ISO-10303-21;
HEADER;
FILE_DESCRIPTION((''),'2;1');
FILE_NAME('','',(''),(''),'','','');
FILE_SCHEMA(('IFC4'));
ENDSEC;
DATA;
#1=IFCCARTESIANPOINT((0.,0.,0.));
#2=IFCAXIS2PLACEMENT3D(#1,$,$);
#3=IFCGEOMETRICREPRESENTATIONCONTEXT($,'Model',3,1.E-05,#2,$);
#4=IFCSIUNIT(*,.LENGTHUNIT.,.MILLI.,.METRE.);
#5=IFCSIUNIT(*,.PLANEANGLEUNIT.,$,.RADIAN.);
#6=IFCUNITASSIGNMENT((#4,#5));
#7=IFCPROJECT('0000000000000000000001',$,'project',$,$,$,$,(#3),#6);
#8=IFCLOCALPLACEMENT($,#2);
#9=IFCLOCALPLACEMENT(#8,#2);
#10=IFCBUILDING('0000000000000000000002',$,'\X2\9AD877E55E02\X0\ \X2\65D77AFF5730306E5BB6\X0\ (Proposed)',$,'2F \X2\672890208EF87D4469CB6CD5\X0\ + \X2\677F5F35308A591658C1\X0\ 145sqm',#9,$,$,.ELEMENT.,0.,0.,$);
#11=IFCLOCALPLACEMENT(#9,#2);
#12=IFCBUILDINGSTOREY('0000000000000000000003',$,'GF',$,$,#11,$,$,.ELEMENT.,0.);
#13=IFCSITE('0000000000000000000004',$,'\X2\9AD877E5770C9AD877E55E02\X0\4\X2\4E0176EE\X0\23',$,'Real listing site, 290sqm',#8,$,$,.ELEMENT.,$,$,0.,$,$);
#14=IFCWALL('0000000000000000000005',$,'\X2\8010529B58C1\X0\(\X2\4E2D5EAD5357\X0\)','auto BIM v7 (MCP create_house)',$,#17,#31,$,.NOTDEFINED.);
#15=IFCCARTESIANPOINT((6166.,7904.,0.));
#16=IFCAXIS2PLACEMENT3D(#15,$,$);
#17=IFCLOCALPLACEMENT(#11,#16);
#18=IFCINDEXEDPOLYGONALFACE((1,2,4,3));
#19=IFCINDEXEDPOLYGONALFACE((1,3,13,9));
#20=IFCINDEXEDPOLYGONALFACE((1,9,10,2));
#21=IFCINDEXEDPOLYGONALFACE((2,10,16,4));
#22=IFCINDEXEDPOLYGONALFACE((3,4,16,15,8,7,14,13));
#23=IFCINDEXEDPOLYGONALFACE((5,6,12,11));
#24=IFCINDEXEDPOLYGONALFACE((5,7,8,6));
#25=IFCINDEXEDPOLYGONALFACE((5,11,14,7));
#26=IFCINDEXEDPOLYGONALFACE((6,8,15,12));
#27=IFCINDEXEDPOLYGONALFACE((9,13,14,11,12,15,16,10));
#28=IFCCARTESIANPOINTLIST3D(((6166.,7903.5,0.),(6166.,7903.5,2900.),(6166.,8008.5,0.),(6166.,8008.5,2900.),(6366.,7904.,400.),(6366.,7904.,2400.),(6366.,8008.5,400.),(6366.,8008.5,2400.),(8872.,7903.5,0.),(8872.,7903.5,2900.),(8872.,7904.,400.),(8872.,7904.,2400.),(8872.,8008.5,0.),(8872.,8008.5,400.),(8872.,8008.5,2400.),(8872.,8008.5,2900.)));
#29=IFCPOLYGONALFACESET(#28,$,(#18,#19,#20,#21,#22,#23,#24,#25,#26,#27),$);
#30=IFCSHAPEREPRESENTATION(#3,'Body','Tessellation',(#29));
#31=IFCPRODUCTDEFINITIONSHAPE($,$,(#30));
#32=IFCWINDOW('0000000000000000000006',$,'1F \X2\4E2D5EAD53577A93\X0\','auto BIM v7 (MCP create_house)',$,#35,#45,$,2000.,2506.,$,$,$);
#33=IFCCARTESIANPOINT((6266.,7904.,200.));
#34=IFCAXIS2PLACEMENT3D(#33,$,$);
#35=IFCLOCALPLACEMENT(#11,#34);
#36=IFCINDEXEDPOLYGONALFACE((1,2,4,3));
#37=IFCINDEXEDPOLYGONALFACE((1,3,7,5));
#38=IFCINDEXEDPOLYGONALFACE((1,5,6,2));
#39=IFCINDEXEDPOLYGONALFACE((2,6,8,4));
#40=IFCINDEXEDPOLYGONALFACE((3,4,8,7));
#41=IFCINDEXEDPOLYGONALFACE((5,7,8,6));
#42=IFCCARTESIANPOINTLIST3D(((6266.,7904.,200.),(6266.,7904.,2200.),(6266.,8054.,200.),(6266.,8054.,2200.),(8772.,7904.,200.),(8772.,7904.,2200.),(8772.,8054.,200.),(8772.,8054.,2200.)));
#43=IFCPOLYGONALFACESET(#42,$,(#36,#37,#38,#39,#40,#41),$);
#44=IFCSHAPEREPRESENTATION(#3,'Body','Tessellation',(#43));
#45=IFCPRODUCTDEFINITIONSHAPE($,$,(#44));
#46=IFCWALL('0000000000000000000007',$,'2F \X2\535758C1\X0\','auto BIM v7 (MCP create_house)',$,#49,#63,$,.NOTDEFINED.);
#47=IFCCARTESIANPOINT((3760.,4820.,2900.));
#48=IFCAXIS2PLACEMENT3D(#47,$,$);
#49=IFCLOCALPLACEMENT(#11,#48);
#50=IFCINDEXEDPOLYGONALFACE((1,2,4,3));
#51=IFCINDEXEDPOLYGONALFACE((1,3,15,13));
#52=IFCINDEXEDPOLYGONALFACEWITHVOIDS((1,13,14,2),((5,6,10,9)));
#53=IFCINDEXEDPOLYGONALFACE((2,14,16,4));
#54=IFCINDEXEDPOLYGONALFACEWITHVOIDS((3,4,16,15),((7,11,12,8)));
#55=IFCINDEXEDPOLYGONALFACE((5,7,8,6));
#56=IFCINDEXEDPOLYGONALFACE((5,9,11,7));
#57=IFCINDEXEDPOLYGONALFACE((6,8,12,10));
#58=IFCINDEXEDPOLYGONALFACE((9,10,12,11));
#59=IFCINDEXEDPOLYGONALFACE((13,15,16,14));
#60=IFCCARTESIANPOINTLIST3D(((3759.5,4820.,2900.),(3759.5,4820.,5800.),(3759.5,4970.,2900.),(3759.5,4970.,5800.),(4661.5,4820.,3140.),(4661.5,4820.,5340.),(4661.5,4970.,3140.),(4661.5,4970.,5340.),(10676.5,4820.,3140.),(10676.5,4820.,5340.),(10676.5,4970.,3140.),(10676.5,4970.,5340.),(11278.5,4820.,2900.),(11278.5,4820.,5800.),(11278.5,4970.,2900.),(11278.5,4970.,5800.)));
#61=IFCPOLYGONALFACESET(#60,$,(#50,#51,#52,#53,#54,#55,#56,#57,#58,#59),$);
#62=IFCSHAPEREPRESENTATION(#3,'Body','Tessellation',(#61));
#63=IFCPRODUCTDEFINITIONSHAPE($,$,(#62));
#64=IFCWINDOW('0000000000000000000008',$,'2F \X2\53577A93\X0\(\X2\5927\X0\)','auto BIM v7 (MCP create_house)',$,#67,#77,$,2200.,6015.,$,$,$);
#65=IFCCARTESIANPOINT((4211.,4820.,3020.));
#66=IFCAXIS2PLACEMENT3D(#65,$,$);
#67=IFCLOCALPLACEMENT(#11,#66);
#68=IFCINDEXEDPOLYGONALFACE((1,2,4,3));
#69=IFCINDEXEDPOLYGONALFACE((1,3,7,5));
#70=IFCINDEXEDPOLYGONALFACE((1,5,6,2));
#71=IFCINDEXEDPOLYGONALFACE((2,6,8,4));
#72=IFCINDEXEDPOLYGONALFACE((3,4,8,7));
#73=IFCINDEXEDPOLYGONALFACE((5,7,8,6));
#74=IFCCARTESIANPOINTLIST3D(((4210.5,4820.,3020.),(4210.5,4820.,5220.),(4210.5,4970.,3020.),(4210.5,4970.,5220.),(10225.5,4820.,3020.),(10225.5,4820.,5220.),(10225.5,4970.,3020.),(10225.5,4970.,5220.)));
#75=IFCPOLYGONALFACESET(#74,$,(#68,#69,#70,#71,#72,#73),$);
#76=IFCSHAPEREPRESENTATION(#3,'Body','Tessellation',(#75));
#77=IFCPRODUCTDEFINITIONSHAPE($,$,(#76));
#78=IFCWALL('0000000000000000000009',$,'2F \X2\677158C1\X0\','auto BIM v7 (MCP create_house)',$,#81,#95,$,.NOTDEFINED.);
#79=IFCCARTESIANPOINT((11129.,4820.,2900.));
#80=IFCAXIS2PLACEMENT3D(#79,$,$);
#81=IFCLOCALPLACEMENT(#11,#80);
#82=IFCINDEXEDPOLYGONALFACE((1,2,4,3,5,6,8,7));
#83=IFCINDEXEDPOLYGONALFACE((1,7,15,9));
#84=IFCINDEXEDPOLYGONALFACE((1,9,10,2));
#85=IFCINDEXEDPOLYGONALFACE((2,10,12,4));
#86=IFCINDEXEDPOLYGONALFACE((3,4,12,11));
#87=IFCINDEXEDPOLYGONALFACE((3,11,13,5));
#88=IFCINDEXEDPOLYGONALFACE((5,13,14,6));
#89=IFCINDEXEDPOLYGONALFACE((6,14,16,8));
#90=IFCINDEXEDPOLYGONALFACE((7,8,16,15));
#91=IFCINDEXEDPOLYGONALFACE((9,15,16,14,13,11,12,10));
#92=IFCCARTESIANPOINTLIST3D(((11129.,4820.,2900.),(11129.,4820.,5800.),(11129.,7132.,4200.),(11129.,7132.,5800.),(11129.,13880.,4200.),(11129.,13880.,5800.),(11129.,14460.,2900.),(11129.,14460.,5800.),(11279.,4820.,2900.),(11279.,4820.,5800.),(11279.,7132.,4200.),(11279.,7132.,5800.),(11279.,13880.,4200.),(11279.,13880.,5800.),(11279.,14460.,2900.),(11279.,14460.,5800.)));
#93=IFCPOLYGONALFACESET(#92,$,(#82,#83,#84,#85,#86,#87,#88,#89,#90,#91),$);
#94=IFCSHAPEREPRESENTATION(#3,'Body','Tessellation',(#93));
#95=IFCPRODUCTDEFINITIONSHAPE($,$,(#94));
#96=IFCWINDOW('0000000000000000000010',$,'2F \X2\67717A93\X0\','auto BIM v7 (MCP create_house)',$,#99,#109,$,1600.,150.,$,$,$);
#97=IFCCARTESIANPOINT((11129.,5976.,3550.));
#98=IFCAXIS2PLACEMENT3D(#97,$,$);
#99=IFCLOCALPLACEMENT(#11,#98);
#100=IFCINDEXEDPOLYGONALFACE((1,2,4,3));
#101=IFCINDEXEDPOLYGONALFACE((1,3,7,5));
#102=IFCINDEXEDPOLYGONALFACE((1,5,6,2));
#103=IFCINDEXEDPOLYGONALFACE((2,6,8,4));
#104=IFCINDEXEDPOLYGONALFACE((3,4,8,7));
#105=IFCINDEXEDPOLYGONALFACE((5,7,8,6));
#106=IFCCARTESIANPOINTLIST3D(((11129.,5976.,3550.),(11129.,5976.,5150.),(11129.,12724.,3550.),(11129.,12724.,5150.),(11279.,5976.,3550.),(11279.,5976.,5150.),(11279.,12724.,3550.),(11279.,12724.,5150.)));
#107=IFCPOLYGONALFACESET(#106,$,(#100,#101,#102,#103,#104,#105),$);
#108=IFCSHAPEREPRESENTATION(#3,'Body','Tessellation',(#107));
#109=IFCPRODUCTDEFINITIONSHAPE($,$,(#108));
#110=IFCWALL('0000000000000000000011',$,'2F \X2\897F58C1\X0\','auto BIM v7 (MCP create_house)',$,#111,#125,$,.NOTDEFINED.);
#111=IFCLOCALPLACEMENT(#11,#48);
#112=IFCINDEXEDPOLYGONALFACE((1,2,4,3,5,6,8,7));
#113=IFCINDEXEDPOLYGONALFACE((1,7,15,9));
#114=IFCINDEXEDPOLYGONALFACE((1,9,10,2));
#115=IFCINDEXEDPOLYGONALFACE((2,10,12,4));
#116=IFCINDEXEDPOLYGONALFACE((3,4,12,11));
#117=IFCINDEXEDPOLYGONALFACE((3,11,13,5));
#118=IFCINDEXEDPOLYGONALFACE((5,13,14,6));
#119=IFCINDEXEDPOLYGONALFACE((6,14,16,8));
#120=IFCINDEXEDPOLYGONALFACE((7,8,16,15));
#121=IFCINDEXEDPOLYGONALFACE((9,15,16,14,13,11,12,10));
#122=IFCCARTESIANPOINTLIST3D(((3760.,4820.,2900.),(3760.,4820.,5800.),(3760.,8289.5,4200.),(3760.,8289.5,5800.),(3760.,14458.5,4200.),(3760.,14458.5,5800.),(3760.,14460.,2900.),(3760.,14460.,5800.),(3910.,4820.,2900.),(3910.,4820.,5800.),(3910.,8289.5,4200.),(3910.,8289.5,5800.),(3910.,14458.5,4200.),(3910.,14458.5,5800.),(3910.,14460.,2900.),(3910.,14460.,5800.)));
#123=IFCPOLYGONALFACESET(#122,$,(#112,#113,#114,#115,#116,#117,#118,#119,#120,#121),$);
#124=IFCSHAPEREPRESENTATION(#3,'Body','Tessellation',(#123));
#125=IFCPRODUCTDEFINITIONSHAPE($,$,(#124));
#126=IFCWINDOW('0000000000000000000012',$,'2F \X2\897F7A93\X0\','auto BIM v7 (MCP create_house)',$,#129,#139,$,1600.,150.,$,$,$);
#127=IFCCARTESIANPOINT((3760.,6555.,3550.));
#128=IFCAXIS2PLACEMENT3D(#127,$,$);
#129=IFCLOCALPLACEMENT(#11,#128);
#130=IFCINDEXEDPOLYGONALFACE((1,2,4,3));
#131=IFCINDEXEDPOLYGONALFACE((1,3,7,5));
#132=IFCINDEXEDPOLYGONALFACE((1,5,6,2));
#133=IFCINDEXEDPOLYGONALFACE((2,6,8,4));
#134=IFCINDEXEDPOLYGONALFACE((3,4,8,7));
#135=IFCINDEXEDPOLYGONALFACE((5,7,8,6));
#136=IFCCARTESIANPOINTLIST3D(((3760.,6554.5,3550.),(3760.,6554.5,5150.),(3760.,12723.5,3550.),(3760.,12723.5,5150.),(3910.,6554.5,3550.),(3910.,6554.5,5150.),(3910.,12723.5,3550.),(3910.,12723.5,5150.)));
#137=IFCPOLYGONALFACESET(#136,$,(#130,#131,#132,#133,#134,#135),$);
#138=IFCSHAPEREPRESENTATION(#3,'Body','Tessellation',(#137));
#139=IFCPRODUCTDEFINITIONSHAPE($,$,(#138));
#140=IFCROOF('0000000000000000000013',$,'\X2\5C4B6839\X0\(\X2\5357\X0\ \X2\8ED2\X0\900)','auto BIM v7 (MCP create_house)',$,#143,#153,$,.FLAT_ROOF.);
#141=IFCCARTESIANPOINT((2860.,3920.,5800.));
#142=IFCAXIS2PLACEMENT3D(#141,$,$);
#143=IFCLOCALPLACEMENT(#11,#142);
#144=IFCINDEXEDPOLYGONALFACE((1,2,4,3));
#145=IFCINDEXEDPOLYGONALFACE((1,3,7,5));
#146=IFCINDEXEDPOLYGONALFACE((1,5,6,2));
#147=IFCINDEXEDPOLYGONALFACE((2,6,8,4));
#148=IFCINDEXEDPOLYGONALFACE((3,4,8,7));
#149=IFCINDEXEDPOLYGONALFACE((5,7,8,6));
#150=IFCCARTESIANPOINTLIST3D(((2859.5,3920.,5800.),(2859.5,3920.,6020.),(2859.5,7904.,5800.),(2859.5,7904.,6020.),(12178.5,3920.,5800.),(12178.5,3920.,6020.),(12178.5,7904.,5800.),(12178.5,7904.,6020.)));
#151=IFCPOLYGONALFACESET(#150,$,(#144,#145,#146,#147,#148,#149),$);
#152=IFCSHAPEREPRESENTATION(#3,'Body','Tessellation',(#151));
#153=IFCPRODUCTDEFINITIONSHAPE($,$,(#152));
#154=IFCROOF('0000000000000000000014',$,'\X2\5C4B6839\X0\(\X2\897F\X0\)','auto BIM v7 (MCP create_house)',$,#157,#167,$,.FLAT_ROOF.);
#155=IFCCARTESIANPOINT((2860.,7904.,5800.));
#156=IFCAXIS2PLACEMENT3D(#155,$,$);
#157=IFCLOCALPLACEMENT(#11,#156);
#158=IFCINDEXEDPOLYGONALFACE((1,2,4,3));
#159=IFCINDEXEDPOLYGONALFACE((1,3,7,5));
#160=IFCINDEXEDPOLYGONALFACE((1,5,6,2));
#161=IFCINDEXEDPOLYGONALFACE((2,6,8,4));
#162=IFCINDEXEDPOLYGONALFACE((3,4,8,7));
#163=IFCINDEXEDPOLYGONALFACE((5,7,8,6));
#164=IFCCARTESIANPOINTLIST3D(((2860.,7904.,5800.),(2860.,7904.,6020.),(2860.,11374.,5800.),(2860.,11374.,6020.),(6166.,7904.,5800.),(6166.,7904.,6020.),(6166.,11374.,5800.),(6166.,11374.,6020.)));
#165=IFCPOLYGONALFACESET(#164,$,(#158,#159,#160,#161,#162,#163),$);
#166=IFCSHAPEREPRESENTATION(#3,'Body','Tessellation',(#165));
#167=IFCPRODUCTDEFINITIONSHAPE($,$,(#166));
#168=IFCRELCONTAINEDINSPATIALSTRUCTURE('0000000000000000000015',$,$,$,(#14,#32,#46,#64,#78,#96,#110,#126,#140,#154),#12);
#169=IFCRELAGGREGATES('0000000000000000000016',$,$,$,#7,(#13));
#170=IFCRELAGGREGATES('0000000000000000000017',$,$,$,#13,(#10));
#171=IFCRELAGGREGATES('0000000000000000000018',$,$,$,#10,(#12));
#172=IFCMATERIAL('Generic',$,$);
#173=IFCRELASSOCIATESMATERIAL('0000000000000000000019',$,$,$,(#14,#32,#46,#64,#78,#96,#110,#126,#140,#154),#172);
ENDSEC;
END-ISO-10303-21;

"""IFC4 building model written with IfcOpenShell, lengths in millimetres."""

from ifc_helpers import new_model, si_unit, frame, frame_2d, origin, place, context, project, spatial, rectangle, extrude, material, element, fill, save


model = new_model("IFC4")

# Units and contexts
model_context = context("Model", 3, precision=1e-05, world=origin())
ifc_project = project(units=[si_unit("LENGTHUNIT", "METRE", prefix="MILLI"), si_unit("PLANEANGLEUNIT", "RADIAN")], contexts=[model_context])

# Site, building, storey
site_placement = place(None, origin())
site = spatial("IfcSite", under=ifc_project, at=site_placement, Name="高知県高知市4丁目23", ObjectType="Real listing site, 290sqm", CompositionType="ELEMENT", RefElevation=0.0)
building_placement = place(site_placement, origin())
building = spatial("IfcBuilding", under=site, at=building_placement, Name="高知市 旗竿地の家 (Proposed)", ObjectType="2F 木造軸組構法 + 板張り外壁 145sqm", CompositionType="ELEMENT", ElevationOfRefHeight=0.0, ElevationOfTerrain=0.0)
storey_placement = place(building_placement, origin())
storey = spatial("IfcBuildingStorey", under=building, at=storey_placement, Name="GF", CompositionType="ELEMENT", Elevation=0.0)

# Shared definitions
ifc_material = material(Name="Generic")

# Wall, opening, window
wall_1_placement = place(storey_placement, frame((6166.0, 7904.0, 0.0)))
wall_1 = element("IfcWall", 1, at=wall_1_placement, inside=storey, material=ifc_material, Name="耐力壁(中庭南)", Description="auto BIM v7 (MCP create_house)", PredefinedType="NOTDEFINED", context=model_context, shape_type="SweptSolid", body=[
    extrude(rectangle(XDim=2706.0, YDim=105.0, at=frame_2d((1353.0, 52.0))), frame((6166.0, 7904.0, 0.0)), (0.0, 0.0, 1.0), 2900.0),
])
opening_1_placement = place(storey_placement, frame((6266.0, 7904.0, 200.0)))
opening_1 = element("IfcOpeningElement", 2, at=opening_1_placement, cuts=wall_1, PredefinedType="NOTDEFINED", context=model_context, shape_type="SweptSolid", body=[
    extrude(rectangle(XDim=2506.0, YDim=150.0, at=frame_2d((1253.0, 75.0))), frame((6266.0, 7904.0, 200.0)), (0.0, 0.0, 1.0), 2000.0),
])
window_1_placement = place(storey_placement, frame((6266.0, 7904.0, 200.0)))
window_1 = element("IfcWindow", 3, at=window_1_placement, inside=storey, material=ifc_material, Name="1F 中庭南窓", Description="auto BIM v7 (MCP create_house)", OverallHeight=2000.0, OverallWidth=2506.0, context=model_context, shape_type="SweptSolid", body=[
    extrude(rectangle(XDim=2506.0, YDim=150.0, at=frame_2d((1253.0, 75.0))), frame((6266.0, 7904.0, 200.0)), (0.0, 0.0, 1.0), 2000.0),
])
fill(opening_1, window_1)

# Walls, openings, windows
wall_2_placement = place(storey_placement, frame((3760.0, 4820.0, 2900.0)))
wall_2 = element("IfcWall", 4, at=wall_2_placement, inside=storey, material=ifc_material, Name="2F 南壁", Description="auto BIM v7 (MCP create_house)", PredefinedType="NOTDEFINED", context=model_context, shape_type="SweptSolid", body=[
    extrude(rectangle(XDim=7519.0, YDim=150.0, at=frame_2d((3759.0, 75.0))), frame((3760.0, 4820.0, 2900.0)), (0.0, 0.0, 1.0), 2900.0),
])
opening_2_placement = place(storey_placement, frame((4211.0, 4820.0, 3020.0)))
opening_2 = element("IfcOpeningElement", 5, at=opening_2_placement, cuts=wall_2, PredefinedType="NOTDEFINED", context=model_context, shape_type="SweptSolid", body=[
    extrude(rectangle(XDim=6015.0, YDim=150.0, at=frame_2d((3007.0, 75.0))), frame((4211.0, 4820.0, 3020.0)), (0.0, 0.0, 1.0), 2200.0),
])
window_2_placement = place(storey_placement, frame((4211.0, 4820.0, 3020.0)))
window_2 = element("IfcWindow", 6, at=window_2_placement, inside=storey, material=ifc_material, Name="2F 南窓(大)", Description="auto BIM v7 (MCP create_house)", OverallHeight=2200.0, OverallWidth=6015.0, context=model_context, shape_type="SweptSolid", body=[
    extrude(rectangle(XDim=6015.0, YDim=150.0, at=frame_2d((3007.0, 75.0))), frame((4211.0, 4820.0, 3020.0)), (0.0, 0.0, 1.0), 2200.0),
])
fill(opening_2, window_2)
wall_3_placement = place(storey_placement, frame((11129.0, 4820.0, 2900.0)))
wall_3 = element("IfcWall", 7, at=wall_3_placement, inside=storey, material=ifc_material, Name="2F 東壁", Description="auto BIM v7 (MCP create_house)", PredefinedType="NOTDEFINED", context=model_context, shape_type="SweptSolid", body=[
    extrude(rectangle(XDim=150.0, YDim=9640.0, at=frame_2d((75.0, 4820.0))), frame((11129.0, 4820.0, 2900.0)), (0.0, 0.0, 1.0), 2900.0),
])
opening_3_placement = place(storey_placement, frame((11129.0, 5976.0, 3550.0)))
opening_3 = element("IfcOpeningElement", 8, at=opening_3_placement, cuts=wall_3, PredefinedType="NOTDEFINED", context=model_context, shape_type="SweptSolid", body=[
    extrude(rectangle(XDim=150.0, YDim=6748.0, at=frame_2d((75.0, 3374.0))), frame((11129.0, 5976.0, 3550.0)), (0.0, 0.0, 1.0), 1600.0),
])
window_3_placement = place(storey_placement, frame((11129.0, 5976.0, 3550.0)))
window_3 = element("IfcWindow", 9, at=window_3_placement, inside=storey, material=ifc_material, Name="2F 東窓", Description="auto BIM v7 (MCP create_house)", OverallHeight=1600.0, OverallWidth=150.0, context=model_context, shape_type="SweptSolid", body=[
    extrude(rectangle(XDim=150.0, YDim=6748.0, at=frame_2d((75.0, 3374.0))), frame((11129.0, 5976.0, 3550.0)), (0.0, 0.0, 1.0), 1600.0),
])
fill(opening_3, window_3)
wall_4_placement = place(storey_placement, frame((3760.0, 4820.0, 2900.0)))
wall_4 = element("IfcWall", 10, at=wall_4_placement, inside=storey, material=ifc_material, Name="2F 西壁", Description="auto BIM v7 (MCP create_house)", PredefinedType="NOTDEFINED", context=model_context, shape_type="SweptSolid", body=[
    extrude(rectangle(XDim=150.0, YDim=9640.0, at=frame_2d((75.0, 4820.0))), frame((3760.0, 4820.0, 2900.0)), (0.0, 0.0, 1.0), 2900.0),
])
opening_4_placement = place(storey_placement, frame((3760.0, 6555.0, 3550.0)))
opening_4 = element("IfcOpeningElement", 11, at=opening_4_placement, cuts=wall_4, PredefinedType="NOTDEFINED", context=model_context, shape_type="SweptSolid", body=[
    extrude(rectangle(XDim=150.0, YDim=6169.0, at=frame_2d((75.0, 3084.0))), frame((3760.0, 6555.0, 3550.0)), (0.0, 0.0, 1.0), 1600.0),
])
window_4_placement = place(storey_placement, frame((3760.0, 6555.0, 3550.0)))
window_4 = element("IfcWindow", 12, at=window_4_placement, inside=storey, material=ifc_material, Name="2F 西窓", Description="auto BIM v7 (MCP create_house)", OverallHeight=1600.0, OverallWidth=150.0, context=model_context, shape_type="SweptSolid", body=[
    extrude(rectangle(XDim=150.0, YDim=6169.0, at=frame_2d((75.0, 3084.0))), frame((3760.0, 6555.0, 3550.0)), (0.0, 0.0, 1.0), 1600.0),
])
fill(opening_4, window_4)

# Roofs
roof_1_placement = place(storey_placement, frame((2860.0, 3920.0, 5800.0)))
element("IfcRoof", 13, at=roof_1_placement, inside=storey, material=ifc_material, Name="屋根(南 軒900)", Description="auto BIM v7 (MCP create_house)", PredefinedType="FLAT_ROOF", context=model_context, shape_type="SweptSolid", body=[
    extrude(rectangle(XDim=9319.0, YDim=3984.0, at=frame_2d((4659.0, 1992.0))), frame((2860.0, 3920.0, 5800.0)), (0.0, 0.0, 1.0), 220.0),
])
roof_2_placement = place(storey_placement, frame((2860.0, 7904.0, 5800.0)))
element("IfcRoof", 14, at=roof_2_placement, inside=storey, material=ifc_material, Name="屋根(西)", Description="auto BIM v7 (MCP create_house)", PredefinedType="FLAT_ROOF", context=model_context, shape_type="SweptSolid", body=[
    extrude(rectangle(XDim=3306.0, YDim=3470.0, at=frame_2d((1653.0, 1735.0))), frame((2860.0, 7904.0, 5800.0)), (0.0, 0.0, 1.0), 220.0),
])

save(model, "model.ifc")
